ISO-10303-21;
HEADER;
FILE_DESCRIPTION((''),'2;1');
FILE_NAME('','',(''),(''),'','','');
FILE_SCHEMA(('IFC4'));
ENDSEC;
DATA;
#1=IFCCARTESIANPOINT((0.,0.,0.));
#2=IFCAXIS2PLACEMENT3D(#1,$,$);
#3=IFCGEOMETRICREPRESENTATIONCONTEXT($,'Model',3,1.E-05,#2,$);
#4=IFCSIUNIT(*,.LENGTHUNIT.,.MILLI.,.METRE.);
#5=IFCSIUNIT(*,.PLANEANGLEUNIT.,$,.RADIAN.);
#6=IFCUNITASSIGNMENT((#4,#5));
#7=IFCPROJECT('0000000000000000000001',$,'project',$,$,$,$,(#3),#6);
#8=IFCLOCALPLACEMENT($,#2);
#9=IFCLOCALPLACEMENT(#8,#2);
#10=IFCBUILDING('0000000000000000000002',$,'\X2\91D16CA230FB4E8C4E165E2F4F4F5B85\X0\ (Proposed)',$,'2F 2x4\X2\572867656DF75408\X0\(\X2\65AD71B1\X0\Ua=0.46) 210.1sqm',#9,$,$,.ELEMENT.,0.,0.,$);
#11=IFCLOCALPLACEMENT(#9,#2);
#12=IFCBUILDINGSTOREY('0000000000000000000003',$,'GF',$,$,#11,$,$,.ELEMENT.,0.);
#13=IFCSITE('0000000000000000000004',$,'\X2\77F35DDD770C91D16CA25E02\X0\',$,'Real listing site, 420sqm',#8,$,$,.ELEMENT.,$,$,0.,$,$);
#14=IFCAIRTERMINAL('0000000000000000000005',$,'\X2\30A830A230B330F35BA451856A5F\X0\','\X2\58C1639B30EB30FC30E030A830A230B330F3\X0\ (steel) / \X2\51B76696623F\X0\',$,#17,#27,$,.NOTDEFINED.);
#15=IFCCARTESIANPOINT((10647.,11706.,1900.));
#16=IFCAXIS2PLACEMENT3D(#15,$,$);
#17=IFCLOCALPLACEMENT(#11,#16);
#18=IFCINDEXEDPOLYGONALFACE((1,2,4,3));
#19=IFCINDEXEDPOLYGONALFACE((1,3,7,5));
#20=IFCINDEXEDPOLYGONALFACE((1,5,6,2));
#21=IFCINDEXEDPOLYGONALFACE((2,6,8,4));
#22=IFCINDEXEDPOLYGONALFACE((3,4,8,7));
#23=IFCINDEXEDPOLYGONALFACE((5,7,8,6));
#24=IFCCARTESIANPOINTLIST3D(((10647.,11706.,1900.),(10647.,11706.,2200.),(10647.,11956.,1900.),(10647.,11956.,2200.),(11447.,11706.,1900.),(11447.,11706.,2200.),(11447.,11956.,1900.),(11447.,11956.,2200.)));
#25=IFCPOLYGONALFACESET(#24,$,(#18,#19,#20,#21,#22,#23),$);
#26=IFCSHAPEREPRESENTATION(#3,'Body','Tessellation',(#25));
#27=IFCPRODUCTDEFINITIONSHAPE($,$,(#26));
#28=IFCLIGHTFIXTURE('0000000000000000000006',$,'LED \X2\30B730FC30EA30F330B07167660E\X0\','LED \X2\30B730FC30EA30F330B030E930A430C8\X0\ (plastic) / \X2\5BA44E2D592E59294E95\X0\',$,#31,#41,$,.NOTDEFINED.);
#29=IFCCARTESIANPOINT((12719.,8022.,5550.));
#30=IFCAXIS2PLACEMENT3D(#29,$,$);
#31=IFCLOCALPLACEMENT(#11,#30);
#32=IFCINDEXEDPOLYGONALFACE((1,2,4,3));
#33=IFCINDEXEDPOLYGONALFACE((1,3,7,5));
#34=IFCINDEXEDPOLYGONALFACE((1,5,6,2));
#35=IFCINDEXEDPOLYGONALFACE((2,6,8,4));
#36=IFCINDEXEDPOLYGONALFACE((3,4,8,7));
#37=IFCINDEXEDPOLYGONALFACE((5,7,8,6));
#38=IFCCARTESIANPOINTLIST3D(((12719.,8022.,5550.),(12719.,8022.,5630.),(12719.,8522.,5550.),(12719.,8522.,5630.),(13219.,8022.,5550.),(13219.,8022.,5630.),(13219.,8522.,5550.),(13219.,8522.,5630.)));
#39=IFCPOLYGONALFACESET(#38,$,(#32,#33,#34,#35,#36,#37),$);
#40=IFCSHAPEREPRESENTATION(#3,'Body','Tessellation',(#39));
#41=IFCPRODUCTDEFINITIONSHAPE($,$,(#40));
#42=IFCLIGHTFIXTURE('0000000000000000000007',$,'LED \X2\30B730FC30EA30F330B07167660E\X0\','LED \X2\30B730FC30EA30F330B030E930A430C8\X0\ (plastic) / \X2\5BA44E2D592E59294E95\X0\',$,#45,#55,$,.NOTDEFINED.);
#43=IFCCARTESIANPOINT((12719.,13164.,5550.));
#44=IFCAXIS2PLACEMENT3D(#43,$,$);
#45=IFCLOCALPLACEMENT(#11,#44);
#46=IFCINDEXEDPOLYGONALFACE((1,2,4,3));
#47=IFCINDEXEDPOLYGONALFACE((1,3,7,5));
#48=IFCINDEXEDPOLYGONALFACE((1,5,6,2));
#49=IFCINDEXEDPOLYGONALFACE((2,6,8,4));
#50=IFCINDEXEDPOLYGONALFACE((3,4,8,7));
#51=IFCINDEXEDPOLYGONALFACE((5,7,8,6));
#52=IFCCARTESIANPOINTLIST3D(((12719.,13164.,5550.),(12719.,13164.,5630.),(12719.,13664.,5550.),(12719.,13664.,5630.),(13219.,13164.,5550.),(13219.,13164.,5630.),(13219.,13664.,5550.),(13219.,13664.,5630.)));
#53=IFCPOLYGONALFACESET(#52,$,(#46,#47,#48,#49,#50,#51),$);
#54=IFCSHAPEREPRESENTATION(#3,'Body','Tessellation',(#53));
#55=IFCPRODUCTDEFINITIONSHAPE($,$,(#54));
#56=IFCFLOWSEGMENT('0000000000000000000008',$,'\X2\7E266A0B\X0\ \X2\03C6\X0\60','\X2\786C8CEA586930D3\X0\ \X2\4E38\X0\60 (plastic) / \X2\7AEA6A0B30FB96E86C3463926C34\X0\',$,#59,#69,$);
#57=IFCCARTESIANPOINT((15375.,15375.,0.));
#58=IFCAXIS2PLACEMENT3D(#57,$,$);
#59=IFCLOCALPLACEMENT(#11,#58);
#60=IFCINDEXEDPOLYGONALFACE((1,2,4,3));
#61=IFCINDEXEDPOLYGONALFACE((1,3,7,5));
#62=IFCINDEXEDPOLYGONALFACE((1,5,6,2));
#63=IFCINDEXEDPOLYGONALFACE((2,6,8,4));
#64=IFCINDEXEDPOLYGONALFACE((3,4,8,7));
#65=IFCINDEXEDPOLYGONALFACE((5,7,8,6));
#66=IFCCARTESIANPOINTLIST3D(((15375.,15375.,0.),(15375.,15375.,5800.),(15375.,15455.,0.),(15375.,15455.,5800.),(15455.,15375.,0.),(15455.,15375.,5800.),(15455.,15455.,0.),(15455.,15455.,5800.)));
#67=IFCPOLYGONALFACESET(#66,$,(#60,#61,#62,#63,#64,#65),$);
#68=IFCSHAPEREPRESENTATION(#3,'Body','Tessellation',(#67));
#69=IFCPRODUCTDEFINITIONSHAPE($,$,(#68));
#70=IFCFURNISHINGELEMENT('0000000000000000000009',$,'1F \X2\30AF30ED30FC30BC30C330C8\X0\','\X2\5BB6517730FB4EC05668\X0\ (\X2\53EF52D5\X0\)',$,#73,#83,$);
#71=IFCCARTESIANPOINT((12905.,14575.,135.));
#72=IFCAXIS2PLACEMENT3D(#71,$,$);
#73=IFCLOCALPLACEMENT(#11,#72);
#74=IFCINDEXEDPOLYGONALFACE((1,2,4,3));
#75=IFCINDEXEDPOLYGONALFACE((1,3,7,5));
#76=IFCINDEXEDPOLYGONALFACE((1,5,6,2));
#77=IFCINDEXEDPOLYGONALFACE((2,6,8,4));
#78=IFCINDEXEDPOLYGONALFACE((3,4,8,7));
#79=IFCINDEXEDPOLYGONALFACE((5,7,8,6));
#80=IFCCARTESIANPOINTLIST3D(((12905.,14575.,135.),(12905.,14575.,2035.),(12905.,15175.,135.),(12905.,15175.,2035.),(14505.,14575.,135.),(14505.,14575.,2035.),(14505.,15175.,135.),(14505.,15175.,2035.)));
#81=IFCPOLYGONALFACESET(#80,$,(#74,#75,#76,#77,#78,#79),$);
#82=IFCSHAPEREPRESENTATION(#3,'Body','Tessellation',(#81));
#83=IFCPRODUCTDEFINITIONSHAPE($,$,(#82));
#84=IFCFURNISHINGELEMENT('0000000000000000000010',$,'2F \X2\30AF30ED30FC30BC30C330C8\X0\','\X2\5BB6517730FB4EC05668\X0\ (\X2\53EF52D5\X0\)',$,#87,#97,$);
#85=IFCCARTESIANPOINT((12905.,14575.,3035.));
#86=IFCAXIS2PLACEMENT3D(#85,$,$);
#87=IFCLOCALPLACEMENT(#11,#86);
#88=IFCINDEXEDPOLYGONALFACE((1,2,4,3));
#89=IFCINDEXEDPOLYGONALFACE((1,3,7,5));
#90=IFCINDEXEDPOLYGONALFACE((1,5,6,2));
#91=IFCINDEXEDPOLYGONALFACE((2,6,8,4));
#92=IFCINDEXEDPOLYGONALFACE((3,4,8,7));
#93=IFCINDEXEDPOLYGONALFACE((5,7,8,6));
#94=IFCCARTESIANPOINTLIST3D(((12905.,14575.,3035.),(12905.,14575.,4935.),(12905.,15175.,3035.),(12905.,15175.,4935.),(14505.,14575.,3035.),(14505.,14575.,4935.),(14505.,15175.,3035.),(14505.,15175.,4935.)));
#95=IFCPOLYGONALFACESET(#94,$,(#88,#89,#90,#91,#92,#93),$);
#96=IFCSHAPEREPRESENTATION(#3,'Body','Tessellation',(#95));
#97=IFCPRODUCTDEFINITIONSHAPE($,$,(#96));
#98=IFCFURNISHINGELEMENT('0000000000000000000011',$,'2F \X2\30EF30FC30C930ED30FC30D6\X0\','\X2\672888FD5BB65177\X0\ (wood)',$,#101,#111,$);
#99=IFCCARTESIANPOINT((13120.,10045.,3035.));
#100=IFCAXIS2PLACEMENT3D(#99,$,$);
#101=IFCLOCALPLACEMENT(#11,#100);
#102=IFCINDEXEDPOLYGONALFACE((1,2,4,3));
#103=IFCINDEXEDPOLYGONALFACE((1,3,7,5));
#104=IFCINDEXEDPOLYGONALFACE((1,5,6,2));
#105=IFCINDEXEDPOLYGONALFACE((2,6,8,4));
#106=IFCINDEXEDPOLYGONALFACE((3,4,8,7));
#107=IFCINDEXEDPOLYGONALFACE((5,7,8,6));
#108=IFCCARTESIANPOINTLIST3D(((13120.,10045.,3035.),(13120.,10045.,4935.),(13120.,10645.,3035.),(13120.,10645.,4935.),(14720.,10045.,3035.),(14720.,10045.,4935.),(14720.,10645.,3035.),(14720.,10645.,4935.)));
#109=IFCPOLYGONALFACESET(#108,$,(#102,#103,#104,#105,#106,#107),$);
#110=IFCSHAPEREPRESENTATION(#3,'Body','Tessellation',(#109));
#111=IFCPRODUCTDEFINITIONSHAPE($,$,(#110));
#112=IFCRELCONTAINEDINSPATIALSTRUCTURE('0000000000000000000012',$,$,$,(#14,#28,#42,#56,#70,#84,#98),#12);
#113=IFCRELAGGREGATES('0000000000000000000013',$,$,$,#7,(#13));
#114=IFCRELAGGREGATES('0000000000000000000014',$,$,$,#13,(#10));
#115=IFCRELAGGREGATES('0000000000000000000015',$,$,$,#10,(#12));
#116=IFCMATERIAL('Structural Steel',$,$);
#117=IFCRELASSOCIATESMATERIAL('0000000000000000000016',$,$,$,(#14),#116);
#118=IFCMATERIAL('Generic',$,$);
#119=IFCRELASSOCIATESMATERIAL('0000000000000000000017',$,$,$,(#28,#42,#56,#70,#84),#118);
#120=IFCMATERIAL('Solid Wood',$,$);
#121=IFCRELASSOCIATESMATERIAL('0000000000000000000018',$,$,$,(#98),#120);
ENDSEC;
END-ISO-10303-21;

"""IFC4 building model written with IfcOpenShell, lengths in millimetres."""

from ifc_helpers import new_model, si_unit, frame, frame_2d, origin, place, context, project, spatial, rectangle, extrude, material, element, save


model = new_model("IFC4")

# Units and contexts
model_context = context("Model", 3, precision=1e-05, world=origin())
ifc_project = project(units=[si_unit("LENGTHUNIT", "METRE", prefix="MILLI"), si_unit("PLANEANGLEUNIT", "RADIAN")], contexts=[model_context])

# Site, building, storey
site_placement = place(None, origin())
site = spatial("IfcSite", under=ifc_project, at=site_placement, Name="石川県金沢市", ObjectType="Real listing site, 420sqm", CompositionType="ELEMENT", RefElevation=0.0)
building_placement = place(site_placement, origin())
building = spatial("IfcBuilding", under=site, at=building_placement, Name="金沢・二世帯住宅 (Proposed)", ObjectType="2F 2x4在来混合(断熱Ua=0.46) 210.1sqm", CompositionType="ELEMENT", ElevationOfRefHeight=0.0, ElevationOfTerrain=0.0)
storey_placement = place(building_placement, origin())
storey = spatial("IfcBuildingStorey", under=building, at=storey_placement, Name="GF", CompositionType="ELEMENT", Elevation=0.0)

# Shared definitions
ifc_material_1 = material(Name="Solid Wood")

# Shared definitions
ifc_material_2 = material(Name="Structural Steel")

# Shared definitions
ifc_material_3 = material(Name="Generic")

# Air terminal
air_terminal_placement = place(storey_placement, frame((10647.0, 11706.0, 1900.0)))
element("IfcAirTerminal", 1, at=air_terminal_placement, inside=storey, material=ifc_material_2, Name="エアコン室内機", Description="壁掛ルームエアコン (steel) / 冷暖房", PredefinedType="NOTDEFINED", context=model_context, shape_type="SweptSolid", body=[
    extrude(rectangle(XDim=800.0, YDim=250.0, at=frame_2d((400.0, 125.0))), frame((10647.0, 11706.0, 1900.0)), (0.0, 0.0, 1.0), 300.0),
])

# Light fixtures
light_fixture_1_placement = place(storey_placement, frame((12719.0, 8022.0, 5550.0)))
element("IfcLightFixture", 2, at=light_fixture_1_placement, inside=storey, material=ifc_material_3, Name="LED シーリング照明", Description="LED シーリングライト (plastic) / 室中央天井", PredefinedType="NOTDEFINED", context=model_context, shape_type="SweptSolid", body=[
    extrude(rectangle(XDim=500.0, YDim=500.0, at=frame_2d((250.0, 250.0))), frame((12719.0, 8022.0, 5550.0)), (0.0, 0.0, 1.0), 80.0),
])
light_fixture_2_placement = place(storey_placement, frame((12719.0, 13164.0, 5550.0)))
element("IfcLightFixture", 3, at=light_fixture_2_placement, inside=storey, material=ifc_material_3, Name="LED シーリング照明", Description="LED シーリングライト (plastic) / 室中央天井", PredefinedType="NOTDEFINED", context=model_context, shape_type="SweptSolid", body=[
    extrude(rectangle(XDim=500.0, YDim=500.0, at=frame_2d((250.0, 250.0))), frame((12719.0, 13164.0, 5550.0)), (0.0, 0.0, 1.0), 80.0),
])

# Flow segment
flow_segment_placement = place(storey_placement, frame((15375.0, 15375.0, 0.0)))
element("IfcFlowSegment", 4, at=flow_segment_placement, inside=storey, material=ifc_material_3, Name="縦樋 φ60", Description="硬質塩ビ 丸60 (plastic) / 竪樋・雨水排水", context=model_context, shape_type="SweptSolid", body=[
    extrude(rectangle(XDim=80.0, YDim=80.0, at=frame_2d((40.0, 40.0))), frame((15375.0, 15375.0, 0.0)), (0.0, 0.0, 1.0), 5800.0),
])

# Furnishing elements
furnishing_1_placement = place(storey_placement, frame((12905.0, 14575.0, 135.0)))
element("IfcFurnishingElement", 5, at=furnishing_1_placement, inside=storey, material=ifc_material_3, Name="1F クローゼット", Description="家具・什器 (可動)", context=model_context, shape_type="SweptSolid", body=[
    extrude(rectangle(XDim=1600.0, YDim=600.0, at=frame_2d((800.0, 300.0))), frame((12905.0, 14575.0, 135.0)), (0.0, 0.0, 1.0), 1900.0),
])
furnishing_2_placement = place(storey_placement, frame((12905.0, 14575.0, 3035.0)))
element("IfcFurnishingElement", 6, at=furnishing_2_placement, inside=storey, material=ifc_material_3, Name="2F クローゼット", Description="家具・什器 (可動)", context=model_context, shape_type="SweptSolid", body=[
    extrude(rectangle(XDim=1600.0, YDim=600.0, at=frame_2d((800.0, 300.0))), frame((12905.0, 14575.0, 3035.0)), (0.0, 0.0, 1.0), 1900.0),
])
furnishing_3_placement = place(storey_placement, frame((13120.0, 10045.0, 3035.0)))
element("IfcFurnishingElement", 7, at=furnishing_3_placement, inside=storey, material=ifc_material_1, Name="2F ワードローブ", Description="木製家具 (wood)", context=model_context, shape_type="SweptSolid", body=[
    extrude(rectangle(XDim=1600.0, YDim=600.0, at=frame_2d((800.0, 300.0))), frame((13120.0, 10045.0, 3035.0)), (0.0, 0.0, 1.0), 1900.0),
])

save(model, "model.ifc")
